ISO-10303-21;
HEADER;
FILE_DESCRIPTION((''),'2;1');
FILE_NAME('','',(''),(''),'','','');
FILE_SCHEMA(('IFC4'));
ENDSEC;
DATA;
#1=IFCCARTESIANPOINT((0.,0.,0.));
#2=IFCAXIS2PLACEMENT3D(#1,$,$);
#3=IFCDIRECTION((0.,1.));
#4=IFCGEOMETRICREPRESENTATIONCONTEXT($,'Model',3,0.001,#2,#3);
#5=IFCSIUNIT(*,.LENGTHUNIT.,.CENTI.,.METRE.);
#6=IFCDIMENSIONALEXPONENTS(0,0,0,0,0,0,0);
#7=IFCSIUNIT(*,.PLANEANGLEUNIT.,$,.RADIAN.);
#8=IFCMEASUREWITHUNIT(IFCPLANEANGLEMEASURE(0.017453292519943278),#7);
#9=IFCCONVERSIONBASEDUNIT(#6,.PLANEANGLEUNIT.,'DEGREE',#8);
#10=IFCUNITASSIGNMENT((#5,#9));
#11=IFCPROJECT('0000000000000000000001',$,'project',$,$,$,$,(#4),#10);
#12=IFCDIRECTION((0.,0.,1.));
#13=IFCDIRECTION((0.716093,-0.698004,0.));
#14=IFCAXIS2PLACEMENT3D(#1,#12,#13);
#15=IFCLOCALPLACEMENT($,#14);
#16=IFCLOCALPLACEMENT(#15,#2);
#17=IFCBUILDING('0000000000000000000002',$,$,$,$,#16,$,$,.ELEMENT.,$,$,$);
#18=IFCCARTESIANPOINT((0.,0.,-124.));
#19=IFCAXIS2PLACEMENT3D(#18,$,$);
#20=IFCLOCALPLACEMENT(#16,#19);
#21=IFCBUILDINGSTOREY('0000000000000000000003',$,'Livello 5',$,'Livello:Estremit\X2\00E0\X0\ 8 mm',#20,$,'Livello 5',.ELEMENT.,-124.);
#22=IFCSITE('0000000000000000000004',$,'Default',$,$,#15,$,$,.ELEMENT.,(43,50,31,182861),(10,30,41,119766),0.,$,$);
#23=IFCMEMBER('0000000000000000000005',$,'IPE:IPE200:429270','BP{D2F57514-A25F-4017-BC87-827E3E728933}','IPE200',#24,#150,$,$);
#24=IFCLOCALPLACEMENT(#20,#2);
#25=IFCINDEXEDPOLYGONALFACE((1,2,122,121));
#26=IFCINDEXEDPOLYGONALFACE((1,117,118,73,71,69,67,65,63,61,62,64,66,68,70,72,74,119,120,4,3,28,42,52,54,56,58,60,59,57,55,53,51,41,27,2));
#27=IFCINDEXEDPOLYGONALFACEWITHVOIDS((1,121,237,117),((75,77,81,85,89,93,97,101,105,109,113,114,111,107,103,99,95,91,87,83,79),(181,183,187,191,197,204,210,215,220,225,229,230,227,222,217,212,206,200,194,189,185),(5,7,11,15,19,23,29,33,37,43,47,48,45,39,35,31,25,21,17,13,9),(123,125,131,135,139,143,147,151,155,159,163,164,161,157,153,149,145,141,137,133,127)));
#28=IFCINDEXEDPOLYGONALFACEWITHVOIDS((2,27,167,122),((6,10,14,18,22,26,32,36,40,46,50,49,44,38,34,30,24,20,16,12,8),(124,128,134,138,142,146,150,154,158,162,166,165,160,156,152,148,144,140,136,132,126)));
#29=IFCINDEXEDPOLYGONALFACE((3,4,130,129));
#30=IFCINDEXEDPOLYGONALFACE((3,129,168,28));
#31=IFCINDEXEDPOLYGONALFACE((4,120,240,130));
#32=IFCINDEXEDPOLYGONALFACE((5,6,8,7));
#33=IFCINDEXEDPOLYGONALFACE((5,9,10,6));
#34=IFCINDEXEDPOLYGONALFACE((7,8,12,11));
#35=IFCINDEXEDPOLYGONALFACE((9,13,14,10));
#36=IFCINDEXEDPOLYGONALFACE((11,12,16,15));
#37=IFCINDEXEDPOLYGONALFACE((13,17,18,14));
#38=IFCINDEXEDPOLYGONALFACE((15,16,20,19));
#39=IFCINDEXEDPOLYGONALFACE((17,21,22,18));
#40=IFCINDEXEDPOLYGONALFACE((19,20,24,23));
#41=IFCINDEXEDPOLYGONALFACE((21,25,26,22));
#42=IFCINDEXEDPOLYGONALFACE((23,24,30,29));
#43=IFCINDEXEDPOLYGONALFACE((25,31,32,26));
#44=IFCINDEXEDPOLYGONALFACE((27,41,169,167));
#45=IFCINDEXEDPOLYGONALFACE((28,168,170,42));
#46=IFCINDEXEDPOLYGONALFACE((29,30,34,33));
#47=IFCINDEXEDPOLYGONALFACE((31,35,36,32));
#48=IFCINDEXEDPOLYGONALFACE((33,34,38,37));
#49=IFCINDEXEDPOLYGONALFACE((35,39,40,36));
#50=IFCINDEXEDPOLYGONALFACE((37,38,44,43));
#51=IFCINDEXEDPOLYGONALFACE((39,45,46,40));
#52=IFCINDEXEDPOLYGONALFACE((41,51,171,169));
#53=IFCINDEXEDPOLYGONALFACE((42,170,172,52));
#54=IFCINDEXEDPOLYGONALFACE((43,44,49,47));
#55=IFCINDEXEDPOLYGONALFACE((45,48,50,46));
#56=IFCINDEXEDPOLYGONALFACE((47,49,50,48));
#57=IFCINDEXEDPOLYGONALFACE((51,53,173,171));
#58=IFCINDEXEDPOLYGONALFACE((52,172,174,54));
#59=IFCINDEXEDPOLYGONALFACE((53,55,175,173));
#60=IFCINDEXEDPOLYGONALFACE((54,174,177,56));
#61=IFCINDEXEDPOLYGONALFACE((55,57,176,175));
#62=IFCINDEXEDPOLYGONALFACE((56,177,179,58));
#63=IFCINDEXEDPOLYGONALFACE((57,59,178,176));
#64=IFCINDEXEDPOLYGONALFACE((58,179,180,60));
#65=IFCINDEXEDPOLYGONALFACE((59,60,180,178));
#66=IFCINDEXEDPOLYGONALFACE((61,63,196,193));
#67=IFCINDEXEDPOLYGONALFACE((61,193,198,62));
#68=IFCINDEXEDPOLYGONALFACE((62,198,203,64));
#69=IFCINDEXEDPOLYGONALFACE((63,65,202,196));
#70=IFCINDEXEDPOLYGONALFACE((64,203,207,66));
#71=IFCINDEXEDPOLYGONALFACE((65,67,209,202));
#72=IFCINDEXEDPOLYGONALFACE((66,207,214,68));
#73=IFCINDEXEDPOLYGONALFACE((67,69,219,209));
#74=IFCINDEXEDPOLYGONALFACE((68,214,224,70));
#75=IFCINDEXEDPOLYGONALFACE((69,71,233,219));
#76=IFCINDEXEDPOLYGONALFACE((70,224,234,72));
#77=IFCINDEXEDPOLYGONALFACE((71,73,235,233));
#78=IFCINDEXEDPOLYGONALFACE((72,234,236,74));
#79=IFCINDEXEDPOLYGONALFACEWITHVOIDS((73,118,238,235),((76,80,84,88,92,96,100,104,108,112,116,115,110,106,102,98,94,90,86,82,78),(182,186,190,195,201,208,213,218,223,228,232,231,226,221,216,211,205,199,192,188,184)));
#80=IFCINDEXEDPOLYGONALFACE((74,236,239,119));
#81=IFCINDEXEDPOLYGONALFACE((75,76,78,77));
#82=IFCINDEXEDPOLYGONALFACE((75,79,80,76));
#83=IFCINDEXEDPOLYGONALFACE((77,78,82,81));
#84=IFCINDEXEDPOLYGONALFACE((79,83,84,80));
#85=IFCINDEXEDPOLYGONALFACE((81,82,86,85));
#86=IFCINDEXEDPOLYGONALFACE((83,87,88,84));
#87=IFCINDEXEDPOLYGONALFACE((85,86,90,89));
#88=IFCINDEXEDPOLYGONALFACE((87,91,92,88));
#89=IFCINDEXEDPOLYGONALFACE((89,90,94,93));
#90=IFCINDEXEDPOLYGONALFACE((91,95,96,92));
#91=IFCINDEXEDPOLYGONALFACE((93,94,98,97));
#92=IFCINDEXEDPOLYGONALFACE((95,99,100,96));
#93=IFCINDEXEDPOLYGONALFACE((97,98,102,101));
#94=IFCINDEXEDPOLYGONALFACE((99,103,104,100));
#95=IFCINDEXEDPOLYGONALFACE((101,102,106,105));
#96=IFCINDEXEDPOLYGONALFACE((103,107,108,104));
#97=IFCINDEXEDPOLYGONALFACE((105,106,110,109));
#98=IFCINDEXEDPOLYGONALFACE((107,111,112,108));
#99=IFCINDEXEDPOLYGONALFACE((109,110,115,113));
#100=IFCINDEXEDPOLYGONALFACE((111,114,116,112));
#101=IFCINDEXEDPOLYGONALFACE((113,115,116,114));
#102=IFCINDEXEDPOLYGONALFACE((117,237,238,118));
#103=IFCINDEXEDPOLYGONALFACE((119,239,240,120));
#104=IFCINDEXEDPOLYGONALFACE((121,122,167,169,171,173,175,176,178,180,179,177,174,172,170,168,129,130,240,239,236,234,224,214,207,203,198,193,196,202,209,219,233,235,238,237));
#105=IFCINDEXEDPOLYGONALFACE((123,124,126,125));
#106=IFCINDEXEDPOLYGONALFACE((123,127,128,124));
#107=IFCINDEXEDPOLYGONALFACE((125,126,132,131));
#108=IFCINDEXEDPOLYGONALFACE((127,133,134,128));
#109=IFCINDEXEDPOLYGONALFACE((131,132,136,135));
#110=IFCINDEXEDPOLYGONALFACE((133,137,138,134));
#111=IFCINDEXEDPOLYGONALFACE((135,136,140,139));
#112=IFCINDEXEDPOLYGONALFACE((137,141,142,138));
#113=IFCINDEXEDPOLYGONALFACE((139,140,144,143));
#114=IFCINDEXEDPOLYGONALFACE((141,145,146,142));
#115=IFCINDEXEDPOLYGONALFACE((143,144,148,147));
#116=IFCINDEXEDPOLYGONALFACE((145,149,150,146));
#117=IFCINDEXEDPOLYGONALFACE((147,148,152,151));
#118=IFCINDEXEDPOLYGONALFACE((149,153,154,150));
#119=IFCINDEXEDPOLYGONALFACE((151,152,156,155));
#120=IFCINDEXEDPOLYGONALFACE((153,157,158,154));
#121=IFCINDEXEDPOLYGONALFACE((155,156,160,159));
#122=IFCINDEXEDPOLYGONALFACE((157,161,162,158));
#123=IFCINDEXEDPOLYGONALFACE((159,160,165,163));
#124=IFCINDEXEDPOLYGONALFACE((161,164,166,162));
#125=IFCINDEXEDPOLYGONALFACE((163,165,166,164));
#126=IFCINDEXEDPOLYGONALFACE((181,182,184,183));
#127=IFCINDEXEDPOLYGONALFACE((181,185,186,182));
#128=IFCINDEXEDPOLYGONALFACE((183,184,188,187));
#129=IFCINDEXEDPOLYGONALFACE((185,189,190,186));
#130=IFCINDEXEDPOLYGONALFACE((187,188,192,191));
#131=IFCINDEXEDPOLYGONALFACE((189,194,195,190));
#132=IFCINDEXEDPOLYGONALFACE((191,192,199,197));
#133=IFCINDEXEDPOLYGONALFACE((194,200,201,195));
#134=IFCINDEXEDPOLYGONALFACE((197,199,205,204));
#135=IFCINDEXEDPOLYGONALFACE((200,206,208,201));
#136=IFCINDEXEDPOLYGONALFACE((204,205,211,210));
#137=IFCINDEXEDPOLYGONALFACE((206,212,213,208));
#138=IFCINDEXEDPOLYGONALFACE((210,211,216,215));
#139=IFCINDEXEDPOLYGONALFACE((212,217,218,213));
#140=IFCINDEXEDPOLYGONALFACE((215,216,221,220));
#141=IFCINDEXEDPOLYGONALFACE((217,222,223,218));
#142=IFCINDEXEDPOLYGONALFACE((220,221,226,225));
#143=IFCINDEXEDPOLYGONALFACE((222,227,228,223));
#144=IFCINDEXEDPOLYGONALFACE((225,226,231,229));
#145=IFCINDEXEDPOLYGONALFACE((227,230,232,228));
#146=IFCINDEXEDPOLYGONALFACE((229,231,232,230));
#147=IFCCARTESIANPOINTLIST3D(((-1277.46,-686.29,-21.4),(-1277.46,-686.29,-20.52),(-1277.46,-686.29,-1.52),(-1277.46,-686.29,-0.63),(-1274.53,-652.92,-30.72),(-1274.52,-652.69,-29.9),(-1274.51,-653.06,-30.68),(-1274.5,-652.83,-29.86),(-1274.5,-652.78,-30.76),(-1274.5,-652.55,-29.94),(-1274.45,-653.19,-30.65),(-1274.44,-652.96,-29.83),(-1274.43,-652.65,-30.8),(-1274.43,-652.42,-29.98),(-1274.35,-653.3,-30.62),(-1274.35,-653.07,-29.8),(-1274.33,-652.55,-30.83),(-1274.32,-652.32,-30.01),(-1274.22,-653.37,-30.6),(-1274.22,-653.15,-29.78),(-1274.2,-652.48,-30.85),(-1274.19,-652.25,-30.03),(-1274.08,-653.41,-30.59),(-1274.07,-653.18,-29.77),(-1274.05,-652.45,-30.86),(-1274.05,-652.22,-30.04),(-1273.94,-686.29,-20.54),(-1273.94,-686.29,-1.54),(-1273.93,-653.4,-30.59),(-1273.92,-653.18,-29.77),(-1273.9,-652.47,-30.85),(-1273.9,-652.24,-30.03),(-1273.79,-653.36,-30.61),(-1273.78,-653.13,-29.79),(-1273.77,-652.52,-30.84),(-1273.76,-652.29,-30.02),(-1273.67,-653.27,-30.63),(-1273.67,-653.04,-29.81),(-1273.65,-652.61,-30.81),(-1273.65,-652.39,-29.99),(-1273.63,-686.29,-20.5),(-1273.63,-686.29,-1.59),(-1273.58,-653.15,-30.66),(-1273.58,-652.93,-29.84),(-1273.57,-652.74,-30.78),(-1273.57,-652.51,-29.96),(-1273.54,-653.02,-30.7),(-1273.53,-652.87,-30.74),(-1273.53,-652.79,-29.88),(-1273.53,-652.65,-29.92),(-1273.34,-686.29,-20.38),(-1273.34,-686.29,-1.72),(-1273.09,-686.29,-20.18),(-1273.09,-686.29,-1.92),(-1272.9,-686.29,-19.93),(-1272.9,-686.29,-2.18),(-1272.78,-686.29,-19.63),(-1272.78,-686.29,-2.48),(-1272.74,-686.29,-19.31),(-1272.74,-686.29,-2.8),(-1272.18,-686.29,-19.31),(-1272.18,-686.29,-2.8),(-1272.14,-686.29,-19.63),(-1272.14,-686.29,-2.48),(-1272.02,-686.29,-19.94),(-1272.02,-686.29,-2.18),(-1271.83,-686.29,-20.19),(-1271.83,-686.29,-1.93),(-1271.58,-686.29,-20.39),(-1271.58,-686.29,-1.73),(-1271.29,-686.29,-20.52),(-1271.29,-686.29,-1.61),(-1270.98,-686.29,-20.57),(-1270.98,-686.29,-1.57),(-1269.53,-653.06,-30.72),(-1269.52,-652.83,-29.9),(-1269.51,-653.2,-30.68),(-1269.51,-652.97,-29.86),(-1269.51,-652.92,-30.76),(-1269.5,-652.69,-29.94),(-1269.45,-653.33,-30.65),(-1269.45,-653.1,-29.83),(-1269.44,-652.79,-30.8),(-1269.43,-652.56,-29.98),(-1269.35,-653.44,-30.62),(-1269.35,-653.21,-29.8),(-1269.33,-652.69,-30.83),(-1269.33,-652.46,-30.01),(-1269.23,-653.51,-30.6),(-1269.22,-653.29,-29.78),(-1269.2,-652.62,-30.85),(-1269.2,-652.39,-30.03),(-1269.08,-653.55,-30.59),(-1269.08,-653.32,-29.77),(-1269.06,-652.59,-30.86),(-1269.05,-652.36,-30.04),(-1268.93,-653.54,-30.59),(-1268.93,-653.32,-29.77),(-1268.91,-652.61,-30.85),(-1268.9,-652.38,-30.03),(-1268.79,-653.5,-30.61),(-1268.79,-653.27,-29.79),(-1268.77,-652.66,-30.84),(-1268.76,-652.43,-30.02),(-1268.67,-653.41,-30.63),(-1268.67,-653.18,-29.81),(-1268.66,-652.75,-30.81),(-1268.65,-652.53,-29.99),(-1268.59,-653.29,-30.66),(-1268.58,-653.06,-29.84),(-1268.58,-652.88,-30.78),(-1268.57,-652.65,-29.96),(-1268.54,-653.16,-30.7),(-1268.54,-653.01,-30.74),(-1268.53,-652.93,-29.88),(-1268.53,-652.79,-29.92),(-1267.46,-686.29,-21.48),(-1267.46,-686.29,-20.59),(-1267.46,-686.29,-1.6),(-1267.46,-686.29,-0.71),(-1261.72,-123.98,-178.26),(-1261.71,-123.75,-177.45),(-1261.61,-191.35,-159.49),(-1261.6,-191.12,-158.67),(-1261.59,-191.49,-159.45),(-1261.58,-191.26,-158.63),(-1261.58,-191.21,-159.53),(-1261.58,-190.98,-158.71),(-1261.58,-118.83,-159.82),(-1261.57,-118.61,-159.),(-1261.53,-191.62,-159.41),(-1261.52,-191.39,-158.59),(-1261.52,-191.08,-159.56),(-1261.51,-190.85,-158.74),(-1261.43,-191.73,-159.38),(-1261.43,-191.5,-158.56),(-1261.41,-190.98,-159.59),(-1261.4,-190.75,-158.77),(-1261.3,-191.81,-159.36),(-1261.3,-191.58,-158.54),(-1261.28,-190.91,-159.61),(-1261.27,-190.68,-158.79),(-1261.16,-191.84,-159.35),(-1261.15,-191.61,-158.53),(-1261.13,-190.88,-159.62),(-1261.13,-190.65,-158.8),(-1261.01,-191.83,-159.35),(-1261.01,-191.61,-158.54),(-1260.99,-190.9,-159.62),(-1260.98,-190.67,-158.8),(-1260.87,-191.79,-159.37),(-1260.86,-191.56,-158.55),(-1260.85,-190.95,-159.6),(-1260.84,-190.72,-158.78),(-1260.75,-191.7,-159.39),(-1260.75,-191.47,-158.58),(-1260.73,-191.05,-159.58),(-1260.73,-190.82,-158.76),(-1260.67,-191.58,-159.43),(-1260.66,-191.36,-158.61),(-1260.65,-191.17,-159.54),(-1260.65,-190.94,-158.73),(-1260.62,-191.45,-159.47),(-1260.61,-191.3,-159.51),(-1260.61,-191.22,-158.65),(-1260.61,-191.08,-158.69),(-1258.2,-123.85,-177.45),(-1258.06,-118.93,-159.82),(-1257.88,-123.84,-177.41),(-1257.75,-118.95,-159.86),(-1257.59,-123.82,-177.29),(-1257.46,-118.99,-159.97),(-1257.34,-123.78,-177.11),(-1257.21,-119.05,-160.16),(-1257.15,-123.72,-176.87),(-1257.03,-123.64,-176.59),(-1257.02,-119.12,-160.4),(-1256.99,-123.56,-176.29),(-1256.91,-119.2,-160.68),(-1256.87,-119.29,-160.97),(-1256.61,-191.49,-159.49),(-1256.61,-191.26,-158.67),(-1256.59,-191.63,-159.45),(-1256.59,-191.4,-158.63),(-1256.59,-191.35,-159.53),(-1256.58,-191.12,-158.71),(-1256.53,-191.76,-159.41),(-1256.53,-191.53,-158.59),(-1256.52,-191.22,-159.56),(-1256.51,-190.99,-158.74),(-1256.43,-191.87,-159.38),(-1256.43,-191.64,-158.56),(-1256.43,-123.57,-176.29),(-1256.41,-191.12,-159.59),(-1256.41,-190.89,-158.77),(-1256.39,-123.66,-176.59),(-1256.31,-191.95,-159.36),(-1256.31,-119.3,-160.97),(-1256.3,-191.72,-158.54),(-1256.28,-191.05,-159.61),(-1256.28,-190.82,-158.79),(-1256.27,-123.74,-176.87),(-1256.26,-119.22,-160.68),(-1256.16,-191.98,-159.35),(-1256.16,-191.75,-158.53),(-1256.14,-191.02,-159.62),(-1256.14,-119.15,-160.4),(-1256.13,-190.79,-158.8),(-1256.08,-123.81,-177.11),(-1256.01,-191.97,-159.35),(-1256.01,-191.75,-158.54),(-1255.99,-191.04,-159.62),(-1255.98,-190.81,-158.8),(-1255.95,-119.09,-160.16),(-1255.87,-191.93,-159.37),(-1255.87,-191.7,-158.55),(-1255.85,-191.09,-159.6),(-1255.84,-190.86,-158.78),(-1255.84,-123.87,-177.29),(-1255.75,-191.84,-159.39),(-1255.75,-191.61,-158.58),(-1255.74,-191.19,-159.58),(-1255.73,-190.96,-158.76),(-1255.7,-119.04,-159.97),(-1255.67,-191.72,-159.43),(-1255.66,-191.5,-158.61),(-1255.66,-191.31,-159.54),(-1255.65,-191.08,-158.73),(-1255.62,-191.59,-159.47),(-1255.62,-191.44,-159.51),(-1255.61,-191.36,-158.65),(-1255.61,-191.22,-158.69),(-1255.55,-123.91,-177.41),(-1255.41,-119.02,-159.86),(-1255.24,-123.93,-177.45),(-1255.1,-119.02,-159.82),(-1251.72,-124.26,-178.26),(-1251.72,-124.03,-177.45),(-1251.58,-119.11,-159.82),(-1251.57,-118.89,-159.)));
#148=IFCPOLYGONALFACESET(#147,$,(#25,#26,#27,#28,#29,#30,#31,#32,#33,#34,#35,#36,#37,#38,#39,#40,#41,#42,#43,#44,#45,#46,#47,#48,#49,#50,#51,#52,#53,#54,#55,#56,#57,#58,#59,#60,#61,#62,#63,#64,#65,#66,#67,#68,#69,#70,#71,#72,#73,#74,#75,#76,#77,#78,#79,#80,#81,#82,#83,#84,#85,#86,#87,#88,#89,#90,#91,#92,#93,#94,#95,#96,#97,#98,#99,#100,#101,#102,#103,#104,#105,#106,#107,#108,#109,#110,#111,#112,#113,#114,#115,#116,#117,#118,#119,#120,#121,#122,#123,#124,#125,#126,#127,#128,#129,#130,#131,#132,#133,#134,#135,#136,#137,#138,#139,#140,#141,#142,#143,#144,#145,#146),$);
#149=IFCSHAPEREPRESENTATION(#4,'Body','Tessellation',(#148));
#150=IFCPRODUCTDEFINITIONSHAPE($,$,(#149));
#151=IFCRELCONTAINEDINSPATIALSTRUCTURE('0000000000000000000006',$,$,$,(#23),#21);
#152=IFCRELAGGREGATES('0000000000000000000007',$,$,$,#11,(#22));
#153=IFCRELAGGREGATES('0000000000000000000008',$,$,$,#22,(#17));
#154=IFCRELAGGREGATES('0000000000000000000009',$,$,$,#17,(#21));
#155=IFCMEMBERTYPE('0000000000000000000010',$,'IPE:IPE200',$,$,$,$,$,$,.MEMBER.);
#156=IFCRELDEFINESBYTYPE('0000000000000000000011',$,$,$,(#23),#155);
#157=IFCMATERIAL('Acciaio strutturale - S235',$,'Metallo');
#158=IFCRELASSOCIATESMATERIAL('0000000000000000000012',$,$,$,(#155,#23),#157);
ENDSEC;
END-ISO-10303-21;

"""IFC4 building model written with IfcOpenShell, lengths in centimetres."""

from ifc_helpers import new_model, entity, si_unit, converted_unit, direction, frame, frame_2d, origin, origin_2d, place, context, project, spatial, circle, i_section, extrude, clip, halfspace, material, type_object, element, save


model = new_model("IFC4")

# Units and contexts
model_context = context("Model", 3, precision=0.001, world=origin(), true_north=direction((0.0, 1.0)))
ifc_project = project(units=[si_unit("LENGTHUNIT", "METRE", prefix="CENTI"), converted_unit("PLANEANGLEUNIT", "DEGREE", entity("IfcPlaneAngleMeasure", 0.017453292519943278), si_unit("PLANEANGLEUNIT", "RADIAN"), dimensions=[0, 0, 0, 0, 0, 0, 0])], contexts=[model_context])

# Site, building, storey
site_placement = place(None, frame((0.0, 0.0, 0.0), z_axis=(0.0, 0.0, 1.0), x_axis=(0.716093, -0.698004, 0.0)))
site = spatial("IfcSite", under=ifc_project, at=site_placement, Name="Default", CompositionType="ELEMENT", RefLatitude=(43, 50, 31, 182861), RefLongitude=(10, 30, 41, 119766), RefElevation=0.0)
building_placement = place(site_placement, origin())
building = spatial("IfcBuilding", under=site, at=building_placement, CompositionType="ELEMENT")
storey_placement = place(building_placement, frame((0.0, 0.0, -124.0)))
storey = spatial("IfcBuildingStorey", under=building, at=storey_placement, Name="Livello 5", ObjectType="Livello:Estremità 8 mm", LongName="Livello 5", CompositionType="ELEMENT", Elevation=-124.0)

# Shared definitions
ifc_material_1 = material(Name="Acciaio strutturale - S235", Category="Metallo")

# Member, openings
member_type_1 = type_object("IfcMemberType", Name="IPE:IPE200", PredefinedType="MEMBER", material=ifc_material_1)
member_1_placement = place(storey_placement, frame((-1273.57, -726.15, 0.07), z_axis=(-0.026952, -0.962871, 0.268612), x_axis=(0.999608, -0.02798, 0.0)))
member_1 = element("IfcMember", 1, at=member_1_placement, inside=storey, type_object=member_type_1, material=ifc_material_1, Name="IPE:IPE200:429270", Description="BP{D2F57514-A25F-4017-BC87-827E3E728933}", ObjectType="IPE200", context=model_context, shape_type="Clipping", body=[
    clip(extrude(i_section(OverallWidth=10.0, OverallDepth=20.0, WebThickness=0.56, FlangeThickness=0.85, FilletRadius=1.2, at=origin_2d()), origin(), (0.0, 0.0, -1.0), 628.04), halfspace(frame((1271.96, 139.66, -39.42), z_axis=(-0.02798, 0.268507, -0.962871), x_axis=(-0.999608, -0.007516, 0.026952)), True)),
])
opening_1_placement = place(member_1_placement, frame((2.0, -9.1, -78.76), z_axis=(0.0, 1.0, 0.0), x_axis=(-1.0, 0.0, 0.0)))
element("IfcOpeningElement", 2, at=opening_1_placement, cuts=member_1, ObjectType="Opening", context=model_context, shape_type="SweptSolid", body=[
    extrude(circle(Radius=0.5, at=frame_2d((-0.5, 0.0), x_axis=(1.0, 0.0))), origin(), (0.0, 0.0, -1.0), 0.95),
])
opening_2_placement = place(member_1_placement, frame((-3.0, -9.1, -78.76), z_axis=(0.0, 1.0, 0.0), x_axis=(-1.0, 0.0, 0.0)))
element("IfcOpeningElement", 3, at=opening_2_placement, cuts=member_1, ObjectType="Opening", context=model_context, shape_type="SweptSolid", body=[
    extrude(circle(Radius=0.5, at=frame_2d((-0.5, 0.0), x_axis=(1.0, 0.0))), origin(), (0.0, 0.0, -1.0), 0.95),
])
opening_3_placement = place(member_1_placement, frame((2.0, -9.1, -558.13), z_axis=(0.0, 1.0, 0.0), x_axis=(-1.0, 0.0, 0.0)))
element("IfcOpeningElement", 4, at=opening_3_placement, cuts=member_1, ObjectType="Opening", context=model_context, shape_type="SweptSolid", body=[
    extrude(circle(Radius=0.5, at=frame_2d((-0.5, 0.0), x_axis=(1.0, 0.0))), origin(), (0.0, 0.0, -1.0), 0.95),
])
opening_4_placement = place(member_1_placement, frame((-3.0, -9.1, -558.13), z_axis=(0.0, 1.0, 0.0), x_axis=(-1.0, 0.0, 0.0)))
element("IfcOpeningElement", 5, at=opening_4_placement, cuts=member_1, ObjectType="Opening", context=model_context, shape_type="SweptSolid", body=[
    extrude(circle(Radius=0.5, at=frame_2d((-0.5, 0.0), x_axis=(1.0, 0.0))), origin(), (0.0, 0.0, -1.0), 0.95),
])

save(model, "model.ifc")
